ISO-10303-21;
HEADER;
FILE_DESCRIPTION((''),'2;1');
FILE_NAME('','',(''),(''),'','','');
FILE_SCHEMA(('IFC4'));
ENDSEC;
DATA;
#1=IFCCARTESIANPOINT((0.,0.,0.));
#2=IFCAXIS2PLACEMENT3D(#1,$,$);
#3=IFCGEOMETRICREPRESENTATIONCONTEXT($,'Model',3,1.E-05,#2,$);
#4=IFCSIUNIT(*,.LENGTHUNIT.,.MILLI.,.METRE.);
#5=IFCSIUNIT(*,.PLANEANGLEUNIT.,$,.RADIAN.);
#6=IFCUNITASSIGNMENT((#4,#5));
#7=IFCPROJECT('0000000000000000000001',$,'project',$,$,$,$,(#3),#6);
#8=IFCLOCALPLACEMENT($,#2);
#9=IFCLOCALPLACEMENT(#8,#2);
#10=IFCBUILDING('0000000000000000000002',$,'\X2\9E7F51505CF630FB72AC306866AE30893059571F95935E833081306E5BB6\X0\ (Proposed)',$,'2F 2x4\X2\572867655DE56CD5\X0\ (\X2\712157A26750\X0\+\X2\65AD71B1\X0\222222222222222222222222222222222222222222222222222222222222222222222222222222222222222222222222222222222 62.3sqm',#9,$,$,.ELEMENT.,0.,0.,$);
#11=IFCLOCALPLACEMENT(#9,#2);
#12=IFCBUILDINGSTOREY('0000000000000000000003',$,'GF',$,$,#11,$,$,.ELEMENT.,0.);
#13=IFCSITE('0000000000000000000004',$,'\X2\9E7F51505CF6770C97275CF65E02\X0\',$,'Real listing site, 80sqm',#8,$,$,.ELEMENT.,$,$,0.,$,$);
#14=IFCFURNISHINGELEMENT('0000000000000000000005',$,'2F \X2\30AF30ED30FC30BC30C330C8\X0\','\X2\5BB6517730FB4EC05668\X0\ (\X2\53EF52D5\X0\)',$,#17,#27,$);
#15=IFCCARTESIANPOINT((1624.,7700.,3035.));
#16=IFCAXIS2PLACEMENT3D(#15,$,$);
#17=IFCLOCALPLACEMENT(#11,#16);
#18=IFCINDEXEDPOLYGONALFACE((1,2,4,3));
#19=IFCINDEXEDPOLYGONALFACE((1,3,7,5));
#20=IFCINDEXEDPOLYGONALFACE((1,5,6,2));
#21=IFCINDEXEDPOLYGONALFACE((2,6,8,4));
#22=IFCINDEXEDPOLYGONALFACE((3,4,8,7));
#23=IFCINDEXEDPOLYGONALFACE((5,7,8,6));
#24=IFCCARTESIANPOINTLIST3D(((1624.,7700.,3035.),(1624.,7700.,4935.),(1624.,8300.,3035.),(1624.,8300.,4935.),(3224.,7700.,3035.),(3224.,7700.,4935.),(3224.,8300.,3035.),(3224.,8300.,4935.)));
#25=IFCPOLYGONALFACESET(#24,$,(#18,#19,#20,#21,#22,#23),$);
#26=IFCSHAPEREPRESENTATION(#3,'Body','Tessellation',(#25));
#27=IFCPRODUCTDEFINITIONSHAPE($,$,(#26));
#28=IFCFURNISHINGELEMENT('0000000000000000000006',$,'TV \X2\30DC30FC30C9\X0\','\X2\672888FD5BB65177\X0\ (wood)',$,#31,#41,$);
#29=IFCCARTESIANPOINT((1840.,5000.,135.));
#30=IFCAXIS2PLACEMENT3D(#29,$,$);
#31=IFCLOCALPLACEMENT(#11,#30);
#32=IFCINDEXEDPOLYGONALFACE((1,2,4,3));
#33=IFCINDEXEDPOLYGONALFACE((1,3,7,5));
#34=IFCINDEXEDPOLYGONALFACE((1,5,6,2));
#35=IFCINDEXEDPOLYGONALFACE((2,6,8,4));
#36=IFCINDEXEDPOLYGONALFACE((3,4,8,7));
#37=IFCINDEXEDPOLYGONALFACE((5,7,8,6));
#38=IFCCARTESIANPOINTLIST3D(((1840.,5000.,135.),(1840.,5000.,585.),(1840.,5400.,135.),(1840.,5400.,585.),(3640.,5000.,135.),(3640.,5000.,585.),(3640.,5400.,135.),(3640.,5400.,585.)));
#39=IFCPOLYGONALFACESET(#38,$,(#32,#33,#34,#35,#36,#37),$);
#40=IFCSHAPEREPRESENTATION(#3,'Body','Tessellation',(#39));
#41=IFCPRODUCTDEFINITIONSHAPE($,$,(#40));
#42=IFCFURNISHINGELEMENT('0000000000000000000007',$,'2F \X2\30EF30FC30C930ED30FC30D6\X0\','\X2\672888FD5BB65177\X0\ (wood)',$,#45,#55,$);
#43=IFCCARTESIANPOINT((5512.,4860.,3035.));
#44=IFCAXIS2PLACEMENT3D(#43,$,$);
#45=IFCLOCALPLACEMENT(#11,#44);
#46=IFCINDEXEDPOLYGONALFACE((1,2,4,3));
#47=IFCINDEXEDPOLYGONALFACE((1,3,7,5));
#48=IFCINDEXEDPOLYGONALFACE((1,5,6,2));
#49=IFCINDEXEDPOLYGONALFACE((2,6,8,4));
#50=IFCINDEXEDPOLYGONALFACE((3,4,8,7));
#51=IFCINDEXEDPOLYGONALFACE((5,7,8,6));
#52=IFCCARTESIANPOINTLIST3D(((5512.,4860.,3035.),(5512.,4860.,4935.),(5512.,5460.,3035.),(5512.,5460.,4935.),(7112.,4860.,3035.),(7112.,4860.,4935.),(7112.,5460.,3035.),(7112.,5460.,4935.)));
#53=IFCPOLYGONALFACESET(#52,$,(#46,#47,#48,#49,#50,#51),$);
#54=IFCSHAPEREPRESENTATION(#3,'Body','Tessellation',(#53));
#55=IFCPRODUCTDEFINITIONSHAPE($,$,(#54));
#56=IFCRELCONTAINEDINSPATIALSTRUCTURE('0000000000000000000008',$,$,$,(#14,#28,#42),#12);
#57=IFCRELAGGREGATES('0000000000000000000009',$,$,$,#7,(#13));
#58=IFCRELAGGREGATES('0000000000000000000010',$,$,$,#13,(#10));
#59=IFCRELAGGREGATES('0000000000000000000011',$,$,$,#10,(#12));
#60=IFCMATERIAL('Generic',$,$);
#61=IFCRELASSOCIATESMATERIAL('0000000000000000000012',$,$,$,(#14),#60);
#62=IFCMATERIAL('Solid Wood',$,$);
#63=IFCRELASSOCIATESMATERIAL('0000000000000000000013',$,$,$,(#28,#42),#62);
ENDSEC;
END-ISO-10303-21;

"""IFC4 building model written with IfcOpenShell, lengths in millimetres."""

from ifc_helpers import new_model, si_unit, frame, frame_2d, origin, place, context, project, spatial, rectangle, extrude, material, element, save


model = new_model("IFC4")

# Units and contexts
model_context = context("Model", 3, precision=1e-05, world=origin())
ifc_project = project(units=[si_unit("LENGTHUNIT", "METRE", prefix="MILLI"), si_unit("PLANEANGLEUNIT", "RADIAN")], contexts=[model_context])

# Site, building, storey
site_placement = place(None, origin())
site = spatial("IfcSite", under=ifc_project, at=site_placement, Name="鹿児島県霧島市", ObjectType="Real listing site, 80sqm", CompositionType="ELEMENT", RefElevation=0.0)
building_placement = place(site_placement, origin())
building = spatial("IfcBuilding", under=site, at=building_placement, Name="鹿児島・犬と暮らす土間広めの家 (Proposed)", ObjectType="2F 2x4在来工法 (無垢材+断熱222222222222222222222222222222222222222222222222222222222222222222222222222222222222222222222222222222222 62.3sqm", CompositionType="ELEMENT", ElevationOfRefHeight=0.0, ElevationOfTerrain=0.0)
storey_placement = place(building_placement, origin())
storey = spatial("IfcBuildingStorey", under=building, at=storey_placement, Name="GF", CompositionType="ELEMENT", Elevation=0.0)

# Shared definitions
ifc_material_1 = material(Name="Solid Wood")

# Shared definitions
ifc_material_2 = material(Name="Generic")

# Furnishing elements
furnishing_1_placement = place(storey_placement, frame((1624.0, 7700.0, 3035.0)))
element("IfcFurnishingElement", 1, at=furnishing_1_placement, inside=storey, material=ifc_material_2, Name="2F クローゼット", Description="家具・什器 (可動)", context=model_context, shape_type="SweptSolid", body=[
    extrude(rectangle(XDim=1600.0, YDim=600.0, at=frame_2d((800.0, 300.0))), frame((1624.0, 7700.0, 3035.0)), (0.0, 0.0, 1.0), 1900.0),
])
furnishing_2_placement = place(storey_placement, frame((1840.0, 5000.0, 135.0)))
element("IfcFurnishingElement", 2, at=furnishing_2_placement, inside=storey, material=ifc_material_1, Name="TV ボード", Description="木製家具 (wood)", context=model_context, shape_type="SweptSolid", body=[
    extrude(rectangle(XDim=1800.0, YDim=400.0, at=frame_2d((900.0, 200.0))), frame((1840.0, 5000.0, 135.0)), (0.0, 0.0, 1.0), 450.0),
])
furnishing_3_placement = place(storey_placement, frame((5512.0, 4860.0, 3035.0)))
element("IfcFurnishingElement", 3, at=furnishing_3_placement, inside=storey, material=ifc_material_1, Name="2F ワードローブ", Description="木製家具 (wood)", context=model_context, shape_type="SweptSolid", body=[
    extrude(rectangle(XDim=1600.0, YDim=600.0, at=frame_2d((800.0, 300.0))), frame((5512.0, 4860.0, 3035.0)), (0.0, 0.0, 1.0), 1900.0),
])

save(model, "model.ifc")
